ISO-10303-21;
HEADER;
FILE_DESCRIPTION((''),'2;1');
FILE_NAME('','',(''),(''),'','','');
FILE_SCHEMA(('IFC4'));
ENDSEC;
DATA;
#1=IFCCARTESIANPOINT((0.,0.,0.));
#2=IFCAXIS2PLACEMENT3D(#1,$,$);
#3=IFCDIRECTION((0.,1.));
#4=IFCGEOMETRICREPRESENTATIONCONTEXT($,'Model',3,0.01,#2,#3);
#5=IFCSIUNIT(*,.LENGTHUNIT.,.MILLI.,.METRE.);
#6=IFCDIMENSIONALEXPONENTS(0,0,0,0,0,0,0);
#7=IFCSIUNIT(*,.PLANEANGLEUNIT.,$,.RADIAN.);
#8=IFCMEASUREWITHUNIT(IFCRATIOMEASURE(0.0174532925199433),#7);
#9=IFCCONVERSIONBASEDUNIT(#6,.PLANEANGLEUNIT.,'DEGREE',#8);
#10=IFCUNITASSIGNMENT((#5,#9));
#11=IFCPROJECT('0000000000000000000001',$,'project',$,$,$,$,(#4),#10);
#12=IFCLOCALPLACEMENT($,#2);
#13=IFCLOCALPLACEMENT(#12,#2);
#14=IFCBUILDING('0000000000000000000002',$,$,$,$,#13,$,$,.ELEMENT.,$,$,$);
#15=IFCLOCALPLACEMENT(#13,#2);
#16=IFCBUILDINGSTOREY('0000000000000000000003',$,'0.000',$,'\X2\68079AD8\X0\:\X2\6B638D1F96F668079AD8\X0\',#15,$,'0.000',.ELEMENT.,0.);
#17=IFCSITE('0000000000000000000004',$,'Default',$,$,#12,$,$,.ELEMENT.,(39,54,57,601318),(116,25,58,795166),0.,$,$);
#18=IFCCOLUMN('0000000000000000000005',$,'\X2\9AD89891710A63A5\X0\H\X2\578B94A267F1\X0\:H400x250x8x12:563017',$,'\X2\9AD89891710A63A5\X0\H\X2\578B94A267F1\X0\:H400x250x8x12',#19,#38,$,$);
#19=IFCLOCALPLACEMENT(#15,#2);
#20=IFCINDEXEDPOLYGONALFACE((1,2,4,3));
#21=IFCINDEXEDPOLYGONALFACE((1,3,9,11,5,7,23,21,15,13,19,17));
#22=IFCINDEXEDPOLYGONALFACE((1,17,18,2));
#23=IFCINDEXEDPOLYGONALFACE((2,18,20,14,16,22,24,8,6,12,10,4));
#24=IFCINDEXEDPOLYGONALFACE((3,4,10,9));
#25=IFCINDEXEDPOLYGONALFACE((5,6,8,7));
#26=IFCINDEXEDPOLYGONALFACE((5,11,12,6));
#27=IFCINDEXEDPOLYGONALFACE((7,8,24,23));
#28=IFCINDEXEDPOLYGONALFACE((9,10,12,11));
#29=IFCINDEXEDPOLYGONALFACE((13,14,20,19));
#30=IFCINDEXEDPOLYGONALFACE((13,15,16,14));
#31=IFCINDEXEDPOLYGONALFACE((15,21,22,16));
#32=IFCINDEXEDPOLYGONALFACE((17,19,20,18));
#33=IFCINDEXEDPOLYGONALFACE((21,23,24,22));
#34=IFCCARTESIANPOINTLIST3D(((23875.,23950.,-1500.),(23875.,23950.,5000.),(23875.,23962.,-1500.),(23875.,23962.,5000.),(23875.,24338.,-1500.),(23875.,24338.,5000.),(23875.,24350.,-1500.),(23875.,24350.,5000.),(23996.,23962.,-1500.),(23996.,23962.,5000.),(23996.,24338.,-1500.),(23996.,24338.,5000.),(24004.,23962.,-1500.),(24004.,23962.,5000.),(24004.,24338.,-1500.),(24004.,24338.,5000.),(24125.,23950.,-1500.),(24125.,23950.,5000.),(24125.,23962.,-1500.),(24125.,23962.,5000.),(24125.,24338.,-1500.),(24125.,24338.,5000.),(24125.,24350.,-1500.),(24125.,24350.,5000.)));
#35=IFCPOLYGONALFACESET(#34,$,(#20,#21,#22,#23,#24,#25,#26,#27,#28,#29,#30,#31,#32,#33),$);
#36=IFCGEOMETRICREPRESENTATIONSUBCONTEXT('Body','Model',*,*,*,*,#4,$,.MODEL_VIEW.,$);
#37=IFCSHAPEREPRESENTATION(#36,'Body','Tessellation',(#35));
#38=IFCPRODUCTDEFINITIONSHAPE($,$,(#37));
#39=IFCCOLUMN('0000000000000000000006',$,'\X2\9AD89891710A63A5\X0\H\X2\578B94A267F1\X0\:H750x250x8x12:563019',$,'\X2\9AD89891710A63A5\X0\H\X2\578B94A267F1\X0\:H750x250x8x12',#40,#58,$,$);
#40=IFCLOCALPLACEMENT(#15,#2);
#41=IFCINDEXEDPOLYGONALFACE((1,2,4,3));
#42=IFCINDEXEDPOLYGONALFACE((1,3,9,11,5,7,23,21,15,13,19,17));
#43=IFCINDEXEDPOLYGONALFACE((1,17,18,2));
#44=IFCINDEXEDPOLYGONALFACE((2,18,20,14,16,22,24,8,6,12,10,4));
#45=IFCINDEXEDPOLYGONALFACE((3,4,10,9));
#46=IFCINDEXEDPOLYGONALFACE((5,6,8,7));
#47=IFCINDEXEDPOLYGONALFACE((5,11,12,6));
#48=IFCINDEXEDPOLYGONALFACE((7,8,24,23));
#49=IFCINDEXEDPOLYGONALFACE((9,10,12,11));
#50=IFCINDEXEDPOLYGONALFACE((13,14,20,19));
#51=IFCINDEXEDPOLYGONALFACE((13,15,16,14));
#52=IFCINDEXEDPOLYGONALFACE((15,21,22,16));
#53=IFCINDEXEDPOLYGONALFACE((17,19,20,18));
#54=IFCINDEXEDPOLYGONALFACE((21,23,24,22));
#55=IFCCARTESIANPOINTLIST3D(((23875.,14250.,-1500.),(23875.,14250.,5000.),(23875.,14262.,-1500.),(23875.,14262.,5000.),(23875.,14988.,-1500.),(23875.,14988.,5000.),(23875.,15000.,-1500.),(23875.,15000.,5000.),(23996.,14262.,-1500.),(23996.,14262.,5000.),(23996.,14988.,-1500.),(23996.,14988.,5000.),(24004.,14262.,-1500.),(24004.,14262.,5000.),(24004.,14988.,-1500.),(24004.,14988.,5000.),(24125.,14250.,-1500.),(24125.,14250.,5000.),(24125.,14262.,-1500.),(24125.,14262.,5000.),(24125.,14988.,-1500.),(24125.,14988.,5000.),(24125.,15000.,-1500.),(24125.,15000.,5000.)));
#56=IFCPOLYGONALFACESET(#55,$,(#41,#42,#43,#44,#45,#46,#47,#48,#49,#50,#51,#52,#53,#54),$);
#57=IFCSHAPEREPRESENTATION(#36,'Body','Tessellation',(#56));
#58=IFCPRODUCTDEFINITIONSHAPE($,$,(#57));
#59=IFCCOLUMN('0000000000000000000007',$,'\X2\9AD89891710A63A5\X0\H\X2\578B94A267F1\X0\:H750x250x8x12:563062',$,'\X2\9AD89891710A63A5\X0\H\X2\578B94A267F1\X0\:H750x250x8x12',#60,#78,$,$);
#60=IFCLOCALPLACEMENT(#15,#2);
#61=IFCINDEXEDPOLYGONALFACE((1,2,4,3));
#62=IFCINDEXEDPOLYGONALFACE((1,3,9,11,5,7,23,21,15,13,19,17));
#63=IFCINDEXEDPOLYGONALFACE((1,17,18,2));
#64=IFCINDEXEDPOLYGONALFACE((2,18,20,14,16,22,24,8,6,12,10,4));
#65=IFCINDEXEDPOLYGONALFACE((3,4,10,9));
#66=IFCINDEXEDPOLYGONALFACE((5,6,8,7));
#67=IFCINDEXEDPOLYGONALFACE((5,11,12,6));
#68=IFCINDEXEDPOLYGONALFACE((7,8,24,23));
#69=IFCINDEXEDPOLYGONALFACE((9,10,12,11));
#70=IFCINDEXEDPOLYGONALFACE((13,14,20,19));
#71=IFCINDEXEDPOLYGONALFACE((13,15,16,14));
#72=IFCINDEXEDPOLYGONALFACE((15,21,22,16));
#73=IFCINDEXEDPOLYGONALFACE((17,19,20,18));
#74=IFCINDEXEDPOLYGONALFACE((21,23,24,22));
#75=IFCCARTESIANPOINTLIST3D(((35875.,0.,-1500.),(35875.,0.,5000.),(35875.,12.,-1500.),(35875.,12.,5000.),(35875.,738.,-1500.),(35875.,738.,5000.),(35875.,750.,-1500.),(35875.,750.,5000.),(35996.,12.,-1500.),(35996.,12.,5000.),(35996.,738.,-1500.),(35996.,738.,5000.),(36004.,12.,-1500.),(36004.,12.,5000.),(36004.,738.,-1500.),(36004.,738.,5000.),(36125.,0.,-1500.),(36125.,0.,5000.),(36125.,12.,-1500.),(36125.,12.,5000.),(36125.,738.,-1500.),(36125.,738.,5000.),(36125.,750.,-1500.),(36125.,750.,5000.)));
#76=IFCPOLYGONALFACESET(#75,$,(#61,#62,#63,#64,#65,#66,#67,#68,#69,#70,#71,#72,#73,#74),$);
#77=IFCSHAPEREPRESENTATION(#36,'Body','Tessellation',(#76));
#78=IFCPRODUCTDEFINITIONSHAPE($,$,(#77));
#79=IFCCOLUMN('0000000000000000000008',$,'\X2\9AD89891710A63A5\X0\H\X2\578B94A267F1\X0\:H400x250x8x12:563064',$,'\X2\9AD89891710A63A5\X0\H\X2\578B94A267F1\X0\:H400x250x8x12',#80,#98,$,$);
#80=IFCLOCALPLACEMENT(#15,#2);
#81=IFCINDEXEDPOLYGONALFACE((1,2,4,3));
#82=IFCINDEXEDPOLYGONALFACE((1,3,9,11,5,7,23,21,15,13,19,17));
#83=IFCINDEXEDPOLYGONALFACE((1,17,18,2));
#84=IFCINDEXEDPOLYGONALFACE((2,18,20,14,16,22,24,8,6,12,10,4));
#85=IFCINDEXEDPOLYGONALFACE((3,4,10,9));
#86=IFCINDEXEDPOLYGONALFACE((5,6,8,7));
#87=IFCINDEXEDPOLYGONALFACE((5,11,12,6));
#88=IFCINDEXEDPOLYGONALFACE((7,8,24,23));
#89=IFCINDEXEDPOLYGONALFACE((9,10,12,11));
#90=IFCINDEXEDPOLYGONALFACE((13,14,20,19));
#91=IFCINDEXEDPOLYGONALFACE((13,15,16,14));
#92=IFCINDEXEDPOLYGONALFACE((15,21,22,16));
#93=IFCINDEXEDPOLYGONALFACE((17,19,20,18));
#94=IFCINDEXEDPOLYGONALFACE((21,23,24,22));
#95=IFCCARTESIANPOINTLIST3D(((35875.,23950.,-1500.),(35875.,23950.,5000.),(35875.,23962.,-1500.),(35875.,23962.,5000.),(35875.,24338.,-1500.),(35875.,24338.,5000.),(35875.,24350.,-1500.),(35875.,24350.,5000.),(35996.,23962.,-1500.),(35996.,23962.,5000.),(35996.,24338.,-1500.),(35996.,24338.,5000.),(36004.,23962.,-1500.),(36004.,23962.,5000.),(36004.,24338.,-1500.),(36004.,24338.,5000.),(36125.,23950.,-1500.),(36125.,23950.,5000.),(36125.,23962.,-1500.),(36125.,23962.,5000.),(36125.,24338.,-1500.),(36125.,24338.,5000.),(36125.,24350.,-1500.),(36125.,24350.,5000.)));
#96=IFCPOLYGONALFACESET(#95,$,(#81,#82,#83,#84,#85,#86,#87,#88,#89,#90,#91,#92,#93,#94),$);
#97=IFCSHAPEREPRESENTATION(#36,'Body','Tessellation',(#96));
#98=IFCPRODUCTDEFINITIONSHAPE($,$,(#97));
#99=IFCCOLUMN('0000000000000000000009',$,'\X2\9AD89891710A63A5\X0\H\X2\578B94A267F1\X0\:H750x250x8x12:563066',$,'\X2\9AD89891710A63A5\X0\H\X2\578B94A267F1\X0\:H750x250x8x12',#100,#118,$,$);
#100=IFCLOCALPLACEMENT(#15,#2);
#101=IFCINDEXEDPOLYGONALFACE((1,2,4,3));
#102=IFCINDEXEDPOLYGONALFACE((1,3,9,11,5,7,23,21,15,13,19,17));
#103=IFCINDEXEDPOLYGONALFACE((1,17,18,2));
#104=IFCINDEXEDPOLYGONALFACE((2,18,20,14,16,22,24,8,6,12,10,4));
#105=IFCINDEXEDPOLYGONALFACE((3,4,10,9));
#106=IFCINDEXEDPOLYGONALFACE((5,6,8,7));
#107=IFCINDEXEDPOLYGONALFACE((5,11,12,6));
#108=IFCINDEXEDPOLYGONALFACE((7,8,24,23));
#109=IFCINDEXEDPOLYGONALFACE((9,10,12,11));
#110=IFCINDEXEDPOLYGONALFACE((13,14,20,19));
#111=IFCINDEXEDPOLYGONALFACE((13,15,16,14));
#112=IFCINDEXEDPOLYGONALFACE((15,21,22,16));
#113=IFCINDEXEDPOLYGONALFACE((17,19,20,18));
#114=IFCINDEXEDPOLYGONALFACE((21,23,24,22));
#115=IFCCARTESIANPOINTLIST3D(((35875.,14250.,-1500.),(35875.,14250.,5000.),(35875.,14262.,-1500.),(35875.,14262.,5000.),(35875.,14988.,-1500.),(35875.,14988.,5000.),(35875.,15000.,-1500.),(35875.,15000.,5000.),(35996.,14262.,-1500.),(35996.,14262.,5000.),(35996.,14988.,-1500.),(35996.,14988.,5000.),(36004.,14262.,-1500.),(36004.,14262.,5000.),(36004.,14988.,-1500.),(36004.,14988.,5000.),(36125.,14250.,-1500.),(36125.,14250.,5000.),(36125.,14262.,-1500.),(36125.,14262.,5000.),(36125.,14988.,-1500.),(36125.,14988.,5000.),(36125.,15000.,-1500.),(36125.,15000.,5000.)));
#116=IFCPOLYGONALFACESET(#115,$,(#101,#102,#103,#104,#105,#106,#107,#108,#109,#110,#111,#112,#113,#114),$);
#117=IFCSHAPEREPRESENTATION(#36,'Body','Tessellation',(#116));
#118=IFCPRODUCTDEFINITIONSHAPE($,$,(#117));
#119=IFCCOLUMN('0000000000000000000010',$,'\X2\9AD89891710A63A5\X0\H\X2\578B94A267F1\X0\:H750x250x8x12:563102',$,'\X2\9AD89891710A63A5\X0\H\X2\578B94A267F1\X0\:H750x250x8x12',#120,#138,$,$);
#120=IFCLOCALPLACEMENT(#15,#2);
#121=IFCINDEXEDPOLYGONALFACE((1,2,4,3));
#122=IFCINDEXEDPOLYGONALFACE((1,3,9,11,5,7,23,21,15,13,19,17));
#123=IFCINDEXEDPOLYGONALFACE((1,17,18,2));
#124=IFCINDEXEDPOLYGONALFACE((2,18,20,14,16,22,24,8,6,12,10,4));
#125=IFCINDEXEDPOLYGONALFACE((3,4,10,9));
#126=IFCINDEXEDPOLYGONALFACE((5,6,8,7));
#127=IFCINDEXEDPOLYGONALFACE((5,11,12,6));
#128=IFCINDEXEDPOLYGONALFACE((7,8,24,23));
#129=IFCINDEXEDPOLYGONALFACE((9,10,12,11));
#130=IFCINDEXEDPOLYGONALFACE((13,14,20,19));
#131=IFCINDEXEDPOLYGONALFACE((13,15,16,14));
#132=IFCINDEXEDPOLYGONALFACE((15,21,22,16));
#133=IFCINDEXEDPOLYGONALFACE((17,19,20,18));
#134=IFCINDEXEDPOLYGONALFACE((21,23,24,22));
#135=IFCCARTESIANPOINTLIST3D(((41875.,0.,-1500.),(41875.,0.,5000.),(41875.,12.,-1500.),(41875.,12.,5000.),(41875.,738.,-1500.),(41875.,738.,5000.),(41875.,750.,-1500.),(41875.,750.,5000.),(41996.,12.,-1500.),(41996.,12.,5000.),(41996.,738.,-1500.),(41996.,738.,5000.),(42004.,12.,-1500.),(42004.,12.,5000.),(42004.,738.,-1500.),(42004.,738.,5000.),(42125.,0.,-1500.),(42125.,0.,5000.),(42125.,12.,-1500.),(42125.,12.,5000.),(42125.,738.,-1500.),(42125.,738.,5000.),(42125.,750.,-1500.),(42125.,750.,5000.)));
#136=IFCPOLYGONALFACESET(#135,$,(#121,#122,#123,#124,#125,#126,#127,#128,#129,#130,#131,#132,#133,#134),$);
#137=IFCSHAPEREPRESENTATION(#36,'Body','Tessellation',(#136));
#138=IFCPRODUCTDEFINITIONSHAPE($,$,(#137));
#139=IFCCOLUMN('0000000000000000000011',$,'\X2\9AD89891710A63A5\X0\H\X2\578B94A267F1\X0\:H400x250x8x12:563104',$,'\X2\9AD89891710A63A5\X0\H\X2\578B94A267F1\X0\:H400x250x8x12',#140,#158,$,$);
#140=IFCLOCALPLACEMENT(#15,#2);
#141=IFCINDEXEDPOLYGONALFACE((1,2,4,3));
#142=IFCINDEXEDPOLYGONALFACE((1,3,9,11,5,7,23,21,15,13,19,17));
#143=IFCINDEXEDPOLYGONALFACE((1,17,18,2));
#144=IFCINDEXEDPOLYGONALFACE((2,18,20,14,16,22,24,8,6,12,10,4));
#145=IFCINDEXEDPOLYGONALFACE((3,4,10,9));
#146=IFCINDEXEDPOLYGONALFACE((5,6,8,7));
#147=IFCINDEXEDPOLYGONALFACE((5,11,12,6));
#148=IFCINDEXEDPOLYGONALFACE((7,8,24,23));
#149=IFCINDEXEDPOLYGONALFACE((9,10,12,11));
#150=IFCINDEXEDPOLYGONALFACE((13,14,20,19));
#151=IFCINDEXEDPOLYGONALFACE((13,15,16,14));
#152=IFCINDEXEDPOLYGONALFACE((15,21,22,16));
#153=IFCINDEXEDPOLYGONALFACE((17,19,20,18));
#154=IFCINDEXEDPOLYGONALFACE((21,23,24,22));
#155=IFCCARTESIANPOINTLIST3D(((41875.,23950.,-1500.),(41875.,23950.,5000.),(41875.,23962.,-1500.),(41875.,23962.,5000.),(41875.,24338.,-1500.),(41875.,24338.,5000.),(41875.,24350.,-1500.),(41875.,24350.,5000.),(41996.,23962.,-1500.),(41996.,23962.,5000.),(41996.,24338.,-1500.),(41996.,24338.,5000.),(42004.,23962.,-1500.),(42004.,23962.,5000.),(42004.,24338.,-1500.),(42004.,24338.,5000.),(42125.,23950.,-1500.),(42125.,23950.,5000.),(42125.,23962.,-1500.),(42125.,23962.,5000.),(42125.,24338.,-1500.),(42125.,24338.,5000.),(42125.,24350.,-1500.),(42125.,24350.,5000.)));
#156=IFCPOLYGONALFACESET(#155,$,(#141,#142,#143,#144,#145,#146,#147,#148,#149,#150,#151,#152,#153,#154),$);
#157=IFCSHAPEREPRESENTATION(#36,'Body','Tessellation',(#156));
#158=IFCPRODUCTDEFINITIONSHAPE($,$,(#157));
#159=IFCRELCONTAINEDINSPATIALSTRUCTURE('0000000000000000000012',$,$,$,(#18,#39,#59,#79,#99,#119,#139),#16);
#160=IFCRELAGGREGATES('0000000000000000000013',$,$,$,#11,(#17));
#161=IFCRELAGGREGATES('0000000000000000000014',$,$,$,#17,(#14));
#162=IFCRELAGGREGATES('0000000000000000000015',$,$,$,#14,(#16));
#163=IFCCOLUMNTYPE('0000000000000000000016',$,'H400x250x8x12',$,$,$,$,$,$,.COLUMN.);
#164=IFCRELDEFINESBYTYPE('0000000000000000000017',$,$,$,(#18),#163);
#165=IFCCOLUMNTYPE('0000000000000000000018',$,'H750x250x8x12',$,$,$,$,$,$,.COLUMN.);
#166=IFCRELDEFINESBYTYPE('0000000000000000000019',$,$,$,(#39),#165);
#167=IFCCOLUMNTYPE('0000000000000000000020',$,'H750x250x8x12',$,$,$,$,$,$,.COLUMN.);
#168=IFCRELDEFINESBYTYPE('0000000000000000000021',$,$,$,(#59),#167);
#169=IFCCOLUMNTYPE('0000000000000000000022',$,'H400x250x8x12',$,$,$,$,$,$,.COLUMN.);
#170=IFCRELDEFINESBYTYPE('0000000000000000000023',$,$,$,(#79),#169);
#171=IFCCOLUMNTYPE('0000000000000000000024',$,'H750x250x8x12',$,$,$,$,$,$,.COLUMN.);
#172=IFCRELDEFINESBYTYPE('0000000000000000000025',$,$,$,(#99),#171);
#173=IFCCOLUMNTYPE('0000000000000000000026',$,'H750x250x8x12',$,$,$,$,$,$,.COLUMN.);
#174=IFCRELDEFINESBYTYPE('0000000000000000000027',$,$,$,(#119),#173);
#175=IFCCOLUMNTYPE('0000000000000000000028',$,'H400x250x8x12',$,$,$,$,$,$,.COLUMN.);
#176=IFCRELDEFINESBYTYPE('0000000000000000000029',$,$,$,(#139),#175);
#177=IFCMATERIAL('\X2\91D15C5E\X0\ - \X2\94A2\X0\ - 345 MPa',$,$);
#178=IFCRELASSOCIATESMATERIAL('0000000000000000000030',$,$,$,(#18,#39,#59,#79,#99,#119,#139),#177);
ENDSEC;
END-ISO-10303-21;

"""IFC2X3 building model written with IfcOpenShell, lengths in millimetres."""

from ifc_helpers import new_model, entity, si_unit, converted_unit, direction, frame, origin, place, context, subcontext, project, spatial, polyline, outline, extrude, source, transform, mapped, material, type_object, type_shapes, element, save


model = new_model("IFC2X3")

# Units and contexts
model_context = context("Model", 3, precision=0.01, world=origin(), true_north=direction((0.0, 1.0)))
body_context = subcontext(model_context, "Body", "Model", "MODEL_VIEW")
ifc_project = project(units=[si_unit("LENGTHUNIT", "METRE", prefix="MILLI"), converted_unit("PLANEANGLEUNIT", "DEGREE", entity("IfcRatioMeasure", 0.0174532925199433), si_unit("PLANEANGLEUNIT", "RADIAN"), dimensions=[0, 0, 0, 0, 0, 0, 0])], contexts=[model_context])

# Site, building, storey
site_placement = place(None, origin())
site = spatial("IfcSite", under=ifc_project, at=site_placement, Name="Default", CompositionType="ELEMENT", RefLatitude=(39, 54, 57, 601318), RefLongitude=(116, 25, 58, 795166), RefElevation=0.0)
building_placement = place(site_placement, origin())
building = spatial("IfcBuilding", under=site, at=building_placement, CompositionType="ELEMENT")
storey_placement = place(building_placement, origin())
storey = spatial("IfcBuildingStorey", under=building, at=storey_placement, Name="0.000", ObjectType="标高:正负零标高", LongName="0.000", CompositionType="ELEMENT", Elevation=0.0)

# Columns
ifc_material_1 = material(Name="金属 - 钢 - 345 MPa")
column_type_1 = type_object("IfcColumnType", Name="H400x250x8x12", PredefinedType="COLUMN")
shared_shape_1 = source(origin(), body_context, "Body", "SweptSolid", [
    extrude(outline(polyline([(188.0, -125.0), (200.0, -125.0), (200.0, 125.0), (188.0, 125.0), (188.0, 4.0), (-188.0, 4.0), (-188.0, 125.0), (-200.0, 125.0), (-200.0, -125.0), (-188.0, -125.0), (-188.0, -4.0), (188.0, -4.0), (188.0, -125.0)])), frame((24000.0, 24150.0, -1500.0), z_axis=(0.0, 0.0, 1.0), x_axis=(0.0, -1.0, 0.0)), (0.0, 0.0, 1.0), 6500.0),
])
type_shapes(column_type_1, [shared_shape_1])
column_1_placement = place(storey_placement, origin())
element("IfcColumn", 1, at=column_1_placement, inside=storey, type_object=column_type_1, material=ifc_material_1, Name="高频焊接H型钢柱:H400x250x8x12:563017", ObjectType="高频焊接H型钢柱:H400x250x8x12", context=body_context, shape_type="MappedRepresentation", body=[
    mapped(shared_shape_1, transform((0.0, 0.0, 0.0), scale=1.0)),
])
column_type_2 = type_object("IfcColumnType", Name="H750x250x8x12", PredefinedType="COLUMN")
shared_shape_2 = source(origin(), body_context, "Body", "SweptSolid", [
    extrude(outline(polyline([(363.0, -125.0), (375.0, -125.0), (375.0, 125.0), (363.0, 125.0), (363.0, 4.0), (-363.0, 4.0), (-363.0, 125.0), (-375.0, 125.0), (-375.0, -125.0), (-363.0, -125.0), (-363.0, -4.0), (363.0, -4.0), (363.0, -125.0)])), frame((24000.0, 14625.0, -1500.0), z_axis=(0.0, 0.0, 1.0), x_axis=(0.0, -1.0, 0.0)), (0.0, 0.0, 1.0), 6500.0),
])
type_shapes(column_type_2, [shared_shape_2])
column_2_placement = place(storey_placement, origin())
element("IfcColumn", 2, at=column_2_placement, inside=storey, type_object=column_type_2, material=ifc_material_1, Name="高频焊接H型钢柱:H750x250x8x12:563019", ObjectType="高频焊接H型钢柱:H750x250x8x12", context=body_context, shape_type="MappedRepresentation", body=[
    mapped(shared_shape_2, transform((0.0, 0.0, 0.0), scale=1.0)),
])
column_type_3 = type_object("IfcColumnType", Name="H750x250x8x12", PredefinedType="COLUMN")
shared_shape_3 = source(origin(), body_context, "Body", "SweptSolid", [
    extrude(outline(polyline([(363.0, -125.0), (375.0, -125.0), (375.0, 125.0), (363.0, 125.0), (363.0, 4.0), (-363.0, 4.0), (-363.0, 125.0), (-375.0, 125.0), (-375.0, -125.0), (-363.0, -125.0), (-363.0, -4.0), (363.0, -4.0), (363.0, -125.0)])), frame((36000.0, 375.0, -1500.0), z_axis=(0.0, 0.0, 1.0), x_axis=(0.0, -1.0, 0.0)), (0.0, 0.0, 1.0), 6500.0),
])
type_shapes(column_type_3, [shared_shape_3])
column_3_placement = place(storey_placement, origin())
element("IfcColumn", 3, at=column_3_placement, inside=storey, type_object=column_type_3, material=ifc_material_1, Name="高频焊接H型钢柱:H750x250x8x12:563062", ObjectType="高频焊接H型钢柱:H750x250x8x12", context=body_context, shape_type="MappedRepresentation", body=[
    mapped(shared_shape_3, transform((0.0, 0.0, 0.0), scale=1.0)),
])
column_type_4 = type_object("IfcColumnType", Name="H400x250x8x12", PredefinedType="COLUMN")
shared_shape_4 = source(origin(), body_context, "Body", "SweptSolid", [
    extrude(outline(polyline([(188.0, -125.0), (200.0, -125.0), (200.0, 125.0), (188.0, 125.0), (188.0, 4.0), (-188.0, 4.0), (-188.0, 125.0), (-200.0, 125.0), (-200.0, -125.0), (-188.0, -125.0), (-188.0, -4.0), (188.0, -4.0), (188.0, -125.0)])), frame((36000.0, 24150.0, -1500.0), z_axis=(0.0, 0.0, 1.0), x_axis=(0.0, -1.0, 0.0)), (0.0, 0.0, 1.0), 6500.0),
])
type_shapes(column_type_4, [shared_shape_4])
column_4_placement = place(storey_placement, origin())
element("IfcColumn", 4, at=column_4_placement, inside=storey, type_object=column_type_4, material=ifc_material_1, Name="高频焊接H型钢柱:H400x250x8x12:563064", ObjectType="高频焊接H型钢柱:H400x250x8x12", context=body_context, shape_type="MappedRepresentation", body=[
    mapped(shared_shape_4, transform((0.0, 0.0, 0.0), scale=1.0)),
])
column_type_5 = type_object("IfcColumnType", Name="H750x250x8x12", PredefinedType="COLUMN")
shared_shape_5 = source(origin(), body_context, "Body", "SweptSolid", [
    extrude(outline(polyline([(363.0, -125.0), (375.0, -125.0), (375.0, 125.0), (363.0, 125.0), (363.0, 4.0), (-363.0, 4.0), (-363.0, 125.0), (-375.0, 125.0), (-375.0, -125.0), (-363.0, -125.0), (-363.0, -4.0), (363.0, -4.0), (363.0, -125.0)])), frame((36000.0, 14625.0, -1500.0), z_axis=(0.0, 0.0, 1.0), x_axis=(0.0, -1.0, 0.0)), (0.0, 0.0, 1.0), 6500.0),
])
type_shapes(column_type_5, [shared_shape_5])
column_5_placement = place(storey_placement, origin())
element("IfcColumn", 5, at=column_5_placement, inside=storey, type_object=column_type_5, material=ifc_material_1, Name="高频焊接H型钢柱:H750x250x8x12:563066", ObjectType="高频焊接H型钢柱:H750x250x8x12", context=body_context, shape_type="MappedRepresentation", body=[
    mapped(shared_shape_5, transform((0.0, 0.0, 0.0), scale=1.0)),
])
column_type_6 = type_object("IfcColumnType", Name="H750x250x8x12", PredefinedType="COLUMN")
shared_shape_6 = source(origin(), body_context, "Body", "SweptSolid", [
    extrude(outline(polyline([(363.0, -125.0), (375.0, -125.0), (375.0, 125.0), (363.0, 125.0), (363.0, 4.0), (-363.0, 4.0), (-363.0, 125.0), (-375.0, 125.0), (-375.0, -125.0), (-363.0, -125.0), (-363.0, -4.0), (363.0, -4.0), (363.0, -125.0)])), frame((42000.0, 375.0, -1500.0), z_axis=(0.0, 0.0, 1.0), x_axis=(0.0, -1.0, 0.0)), (0.0, 0.0, 1.0), 6500.0),
])
type_shapes(column_type_6, [shared_shape_6])
column_6_placement = place(storey_placement, origin())
element("IfcColumn", 6, at=column_6_placement, inside=storey, type_object=column_type_6, material=ifc_material_1, Name="高频焊接H型钢柱:H750x250x8x12:563102", ObjectType="高频焊接H型钢柱:H750x250x8x12", context=body_context, shape_type="MappedRepresentation", body=[
    mapped(shared_shape_6, transform((0.0, 0.0, 0.0), scale=1.0)),
])
column_type_7 = type_object("IfcColumnType", Name="H400x250x8x12", PredefinedType="COLUMN")
shared_shape_7 = source(origin(), body_context, "Body", "SweptSolid", [
    extrude(outline(polyline([(188.0, -125.0), (200.0, -125.0), (200.0, 125.0), (188.0, 125.0), (188.0, 4.0), (-188.0, 4.0), (-188.0, 125.0), (-200.0, 125.0), (-200.0, -125.0), (-188.0, -125.0), (-188.0, -4.0), (188.0, -4.0), (188.0, -125.0)])), frame((42000.0, 24150.0, -1500.0), z_axis=(0.0, 0.0, 1.0), x_axis=(0.0, -1.0, 0.0)), (0.0, 0.0, 1.0), 6500.0),
])
type_shapes(column_type_7, [shared_shape_7])
column_7_placement = place(storey_placement, origin())
element("IfcColumn", 7, at=column_7_placement, inside=storey, type_object=column_type_7, material=ifc_material_1, Name="高频焊接H型钢柱:H400x250x8x12:563104", ObjectType="高频焊接H型钢柱:H400x250x8x12", context=body_context, shape_type="MappedRepresentation", body=[
    mapped(shared_shape_7, transform((0.0, 0.0, 0.0), scale=1.0)),
])

save(model, "model.ifc")
